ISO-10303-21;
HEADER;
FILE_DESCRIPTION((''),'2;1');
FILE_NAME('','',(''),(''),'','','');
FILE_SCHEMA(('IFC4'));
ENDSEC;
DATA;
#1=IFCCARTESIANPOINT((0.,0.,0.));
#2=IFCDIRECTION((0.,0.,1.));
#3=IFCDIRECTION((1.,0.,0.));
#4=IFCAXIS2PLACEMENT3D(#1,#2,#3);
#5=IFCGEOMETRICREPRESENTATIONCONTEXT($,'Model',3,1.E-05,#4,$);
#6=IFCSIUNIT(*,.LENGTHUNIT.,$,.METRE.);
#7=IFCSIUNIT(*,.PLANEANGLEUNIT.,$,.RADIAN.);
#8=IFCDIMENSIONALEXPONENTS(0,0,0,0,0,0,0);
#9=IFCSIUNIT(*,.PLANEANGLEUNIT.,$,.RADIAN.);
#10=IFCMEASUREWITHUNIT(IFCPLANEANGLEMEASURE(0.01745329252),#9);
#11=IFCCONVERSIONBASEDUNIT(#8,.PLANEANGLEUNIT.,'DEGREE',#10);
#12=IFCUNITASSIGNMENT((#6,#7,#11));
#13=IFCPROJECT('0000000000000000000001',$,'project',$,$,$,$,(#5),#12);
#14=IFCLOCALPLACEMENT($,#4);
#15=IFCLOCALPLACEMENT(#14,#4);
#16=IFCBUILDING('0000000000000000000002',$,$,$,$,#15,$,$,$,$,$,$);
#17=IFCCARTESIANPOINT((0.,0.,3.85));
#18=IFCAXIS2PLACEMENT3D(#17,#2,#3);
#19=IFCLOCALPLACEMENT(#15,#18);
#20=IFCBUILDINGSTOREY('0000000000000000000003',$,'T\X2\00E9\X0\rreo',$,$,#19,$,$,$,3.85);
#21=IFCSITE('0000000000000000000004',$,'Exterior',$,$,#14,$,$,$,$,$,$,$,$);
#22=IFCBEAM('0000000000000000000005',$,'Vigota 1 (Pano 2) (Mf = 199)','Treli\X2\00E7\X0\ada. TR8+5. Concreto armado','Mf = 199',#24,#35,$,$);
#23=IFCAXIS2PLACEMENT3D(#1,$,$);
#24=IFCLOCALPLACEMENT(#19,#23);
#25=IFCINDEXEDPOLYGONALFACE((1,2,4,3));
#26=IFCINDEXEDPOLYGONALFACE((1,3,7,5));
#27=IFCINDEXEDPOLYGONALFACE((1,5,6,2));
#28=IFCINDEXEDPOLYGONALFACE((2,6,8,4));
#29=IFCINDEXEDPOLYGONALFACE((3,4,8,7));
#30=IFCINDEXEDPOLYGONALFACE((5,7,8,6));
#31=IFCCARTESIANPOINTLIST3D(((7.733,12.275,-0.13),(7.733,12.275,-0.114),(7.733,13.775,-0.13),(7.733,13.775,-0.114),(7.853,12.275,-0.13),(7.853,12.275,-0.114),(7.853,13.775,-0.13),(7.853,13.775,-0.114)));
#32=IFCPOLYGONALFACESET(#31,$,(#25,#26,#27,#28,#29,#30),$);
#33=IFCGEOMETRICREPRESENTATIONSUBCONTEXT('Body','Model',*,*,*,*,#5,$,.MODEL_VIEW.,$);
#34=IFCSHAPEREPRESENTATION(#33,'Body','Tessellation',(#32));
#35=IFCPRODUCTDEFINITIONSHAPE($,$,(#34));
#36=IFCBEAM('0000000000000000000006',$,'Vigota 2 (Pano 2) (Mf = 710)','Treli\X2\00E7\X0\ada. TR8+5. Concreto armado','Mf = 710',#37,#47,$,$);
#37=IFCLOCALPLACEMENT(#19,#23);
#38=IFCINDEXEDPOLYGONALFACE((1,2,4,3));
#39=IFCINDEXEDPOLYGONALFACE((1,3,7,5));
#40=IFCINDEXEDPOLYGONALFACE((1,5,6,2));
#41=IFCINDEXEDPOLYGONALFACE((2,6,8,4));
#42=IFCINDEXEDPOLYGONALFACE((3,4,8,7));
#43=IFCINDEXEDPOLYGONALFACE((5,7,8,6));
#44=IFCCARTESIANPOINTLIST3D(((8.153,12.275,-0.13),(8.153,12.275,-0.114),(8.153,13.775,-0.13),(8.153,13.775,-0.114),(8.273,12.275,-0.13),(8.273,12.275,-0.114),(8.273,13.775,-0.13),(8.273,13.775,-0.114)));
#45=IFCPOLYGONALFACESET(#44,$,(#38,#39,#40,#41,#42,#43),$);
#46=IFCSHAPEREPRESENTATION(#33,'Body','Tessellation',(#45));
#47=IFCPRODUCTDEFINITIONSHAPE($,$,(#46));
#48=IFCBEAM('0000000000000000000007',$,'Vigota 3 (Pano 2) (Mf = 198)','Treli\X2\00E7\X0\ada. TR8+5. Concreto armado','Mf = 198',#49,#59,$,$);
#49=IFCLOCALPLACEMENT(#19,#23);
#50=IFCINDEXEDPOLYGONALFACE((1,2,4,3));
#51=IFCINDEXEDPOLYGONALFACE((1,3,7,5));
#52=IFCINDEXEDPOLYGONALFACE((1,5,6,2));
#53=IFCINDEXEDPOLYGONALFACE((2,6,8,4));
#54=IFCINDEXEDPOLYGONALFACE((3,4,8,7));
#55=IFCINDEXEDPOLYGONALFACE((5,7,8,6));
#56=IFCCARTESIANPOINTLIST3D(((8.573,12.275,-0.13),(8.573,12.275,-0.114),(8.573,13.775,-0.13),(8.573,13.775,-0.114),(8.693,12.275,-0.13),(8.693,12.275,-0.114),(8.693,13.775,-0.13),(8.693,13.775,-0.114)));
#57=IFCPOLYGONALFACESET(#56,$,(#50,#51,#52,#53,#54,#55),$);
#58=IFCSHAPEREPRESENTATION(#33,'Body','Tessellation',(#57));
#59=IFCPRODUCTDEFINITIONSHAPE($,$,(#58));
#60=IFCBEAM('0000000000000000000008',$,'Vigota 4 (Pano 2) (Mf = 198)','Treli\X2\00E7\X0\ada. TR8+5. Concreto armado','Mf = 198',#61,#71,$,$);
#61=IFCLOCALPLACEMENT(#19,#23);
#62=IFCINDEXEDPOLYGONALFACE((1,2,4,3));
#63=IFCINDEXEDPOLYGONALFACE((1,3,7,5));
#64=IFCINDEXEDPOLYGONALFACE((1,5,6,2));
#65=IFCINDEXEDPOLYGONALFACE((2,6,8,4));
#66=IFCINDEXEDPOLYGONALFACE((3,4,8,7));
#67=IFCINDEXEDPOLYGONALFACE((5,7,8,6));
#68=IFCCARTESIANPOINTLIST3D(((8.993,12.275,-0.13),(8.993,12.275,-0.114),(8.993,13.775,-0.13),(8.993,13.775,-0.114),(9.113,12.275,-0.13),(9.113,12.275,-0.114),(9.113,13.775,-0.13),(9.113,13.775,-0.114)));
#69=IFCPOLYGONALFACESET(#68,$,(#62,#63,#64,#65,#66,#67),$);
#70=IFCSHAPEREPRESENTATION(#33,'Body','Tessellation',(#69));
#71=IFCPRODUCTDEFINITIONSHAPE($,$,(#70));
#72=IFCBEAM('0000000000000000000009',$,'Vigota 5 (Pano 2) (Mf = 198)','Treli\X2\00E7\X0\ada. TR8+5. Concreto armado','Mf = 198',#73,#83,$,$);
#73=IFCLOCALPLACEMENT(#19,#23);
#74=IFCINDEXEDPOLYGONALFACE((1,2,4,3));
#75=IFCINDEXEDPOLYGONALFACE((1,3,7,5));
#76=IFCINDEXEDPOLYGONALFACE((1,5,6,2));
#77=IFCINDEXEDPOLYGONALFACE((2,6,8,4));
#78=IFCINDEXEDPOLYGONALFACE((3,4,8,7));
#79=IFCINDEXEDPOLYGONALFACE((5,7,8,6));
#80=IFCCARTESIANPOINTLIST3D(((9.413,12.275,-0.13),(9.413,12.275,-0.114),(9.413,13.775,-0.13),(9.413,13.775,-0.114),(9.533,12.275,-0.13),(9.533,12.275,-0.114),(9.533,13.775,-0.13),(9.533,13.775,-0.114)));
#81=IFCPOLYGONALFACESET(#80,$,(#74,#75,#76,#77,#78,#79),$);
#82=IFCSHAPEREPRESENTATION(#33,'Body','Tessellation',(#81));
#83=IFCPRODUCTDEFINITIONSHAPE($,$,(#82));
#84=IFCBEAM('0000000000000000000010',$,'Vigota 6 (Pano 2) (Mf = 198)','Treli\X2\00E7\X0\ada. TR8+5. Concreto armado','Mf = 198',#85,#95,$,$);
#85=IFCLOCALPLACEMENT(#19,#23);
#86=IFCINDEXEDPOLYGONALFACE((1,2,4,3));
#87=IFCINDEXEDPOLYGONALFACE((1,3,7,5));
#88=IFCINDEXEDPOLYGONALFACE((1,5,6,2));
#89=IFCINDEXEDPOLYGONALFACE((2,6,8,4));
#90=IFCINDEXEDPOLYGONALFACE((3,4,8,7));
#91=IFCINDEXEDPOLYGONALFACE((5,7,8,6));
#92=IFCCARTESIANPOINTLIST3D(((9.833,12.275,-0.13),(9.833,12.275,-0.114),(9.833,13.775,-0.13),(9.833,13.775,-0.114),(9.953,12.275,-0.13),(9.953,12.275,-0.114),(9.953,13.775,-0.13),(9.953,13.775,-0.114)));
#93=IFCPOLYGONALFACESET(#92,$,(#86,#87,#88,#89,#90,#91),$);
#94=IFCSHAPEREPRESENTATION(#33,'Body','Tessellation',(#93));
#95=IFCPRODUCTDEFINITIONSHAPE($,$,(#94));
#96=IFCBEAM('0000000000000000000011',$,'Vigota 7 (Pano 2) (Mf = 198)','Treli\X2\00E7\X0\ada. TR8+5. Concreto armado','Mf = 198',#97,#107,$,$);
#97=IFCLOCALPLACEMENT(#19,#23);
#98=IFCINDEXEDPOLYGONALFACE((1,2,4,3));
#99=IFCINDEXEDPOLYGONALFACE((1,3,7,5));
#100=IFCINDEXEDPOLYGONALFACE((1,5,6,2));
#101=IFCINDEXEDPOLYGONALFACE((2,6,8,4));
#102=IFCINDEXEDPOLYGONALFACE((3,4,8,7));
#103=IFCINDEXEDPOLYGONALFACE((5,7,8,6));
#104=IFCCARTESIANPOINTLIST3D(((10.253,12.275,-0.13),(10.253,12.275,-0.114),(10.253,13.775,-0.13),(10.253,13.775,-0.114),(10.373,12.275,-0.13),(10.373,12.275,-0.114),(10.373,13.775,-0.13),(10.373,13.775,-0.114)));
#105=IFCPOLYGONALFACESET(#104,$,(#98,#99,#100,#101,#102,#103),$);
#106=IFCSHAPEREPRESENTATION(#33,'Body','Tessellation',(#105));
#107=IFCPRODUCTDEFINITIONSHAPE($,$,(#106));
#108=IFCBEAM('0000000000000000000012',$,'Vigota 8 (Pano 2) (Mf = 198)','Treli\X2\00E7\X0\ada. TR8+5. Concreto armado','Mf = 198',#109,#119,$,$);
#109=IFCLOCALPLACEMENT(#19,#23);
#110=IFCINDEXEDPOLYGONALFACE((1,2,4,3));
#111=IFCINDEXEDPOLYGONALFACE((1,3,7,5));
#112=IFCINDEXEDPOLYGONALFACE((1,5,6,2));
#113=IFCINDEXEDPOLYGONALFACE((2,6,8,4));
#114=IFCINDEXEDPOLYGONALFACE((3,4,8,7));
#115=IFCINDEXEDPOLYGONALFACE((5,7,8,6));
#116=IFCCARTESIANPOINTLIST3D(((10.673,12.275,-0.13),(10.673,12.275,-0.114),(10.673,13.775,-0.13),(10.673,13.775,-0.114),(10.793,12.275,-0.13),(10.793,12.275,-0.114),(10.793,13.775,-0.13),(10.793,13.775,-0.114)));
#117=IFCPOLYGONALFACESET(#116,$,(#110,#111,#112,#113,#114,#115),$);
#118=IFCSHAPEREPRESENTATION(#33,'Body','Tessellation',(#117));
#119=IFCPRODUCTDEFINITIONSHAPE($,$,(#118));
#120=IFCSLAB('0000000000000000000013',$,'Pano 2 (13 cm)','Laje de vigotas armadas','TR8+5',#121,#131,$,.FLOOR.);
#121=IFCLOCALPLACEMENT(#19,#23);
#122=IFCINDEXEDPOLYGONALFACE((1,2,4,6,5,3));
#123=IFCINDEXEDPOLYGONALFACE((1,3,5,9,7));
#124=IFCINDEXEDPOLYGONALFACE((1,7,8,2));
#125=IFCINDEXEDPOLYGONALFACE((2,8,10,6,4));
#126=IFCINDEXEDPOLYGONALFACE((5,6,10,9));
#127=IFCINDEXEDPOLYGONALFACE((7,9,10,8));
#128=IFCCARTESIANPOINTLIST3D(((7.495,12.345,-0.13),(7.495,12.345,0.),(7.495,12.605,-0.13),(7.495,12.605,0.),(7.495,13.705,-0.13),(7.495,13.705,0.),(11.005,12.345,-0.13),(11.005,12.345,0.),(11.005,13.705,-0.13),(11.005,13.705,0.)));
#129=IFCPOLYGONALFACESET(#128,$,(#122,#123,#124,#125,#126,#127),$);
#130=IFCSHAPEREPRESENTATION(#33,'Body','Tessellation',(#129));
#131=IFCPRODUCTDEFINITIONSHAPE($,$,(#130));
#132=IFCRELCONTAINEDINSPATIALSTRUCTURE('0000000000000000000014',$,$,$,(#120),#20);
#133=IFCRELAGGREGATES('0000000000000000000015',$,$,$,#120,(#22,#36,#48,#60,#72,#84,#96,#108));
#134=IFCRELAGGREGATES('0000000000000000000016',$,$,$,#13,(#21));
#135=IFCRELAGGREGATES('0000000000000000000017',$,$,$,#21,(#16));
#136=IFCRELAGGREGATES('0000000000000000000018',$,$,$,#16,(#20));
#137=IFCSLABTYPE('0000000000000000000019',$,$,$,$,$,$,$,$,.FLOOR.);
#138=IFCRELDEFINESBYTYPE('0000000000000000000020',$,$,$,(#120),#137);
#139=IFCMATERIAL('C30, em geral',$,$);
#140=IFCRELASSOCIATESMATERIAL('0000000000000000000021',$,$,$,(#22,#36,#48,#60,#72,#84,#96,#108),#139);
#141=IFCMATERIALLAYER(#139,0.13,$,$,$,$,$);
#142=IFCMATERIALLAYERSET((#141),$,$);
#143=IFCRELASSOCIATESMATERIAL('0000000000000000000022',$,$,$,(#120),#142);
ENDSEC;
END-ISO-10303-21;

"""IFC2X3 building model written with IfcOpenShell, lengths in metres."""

from ifc_helpers import new_model, entity, si_unit, converted_unit, frame, origin_with_axes, place, context, subcontext, project, spatial, polyline, outline, extrude, material, layer, layer_set, layer_usage, type_object, element, aggregate, save


model = new_model("IFC2X3")

# Units and contexts
model_context = context("Model", 3, precision=1e-05, world=origin_with_axes())
body_context = subcontext(model_context, "Body", "Model", "MODEL_VIEW")
ifc_project = project(units=[si_unit("LENGTHUNIT", "METRE"), si_unit("PLANEANGLEUNIT", "RADIAN"), converted_unit("PLANEANGLEUNIT", "DEGREE", entity("IfcPlaneAngleMeasure", 0.01745329252), si_unit("PLANEANGLEUNIT", "RADIAN"), dimensions=[0, 0, 0, 0, 0, 0, 0])], contexts=[model_context])

# Beams
ifc_material = material(Name="C30, em geral")
site_placement = place(None, origin_with_axes())
building_placement = place(site_placement, origin_with_axes())
storey_placement = place(building_placement, frame((0.0, 0.0, 3.85), z_axis=(0.0, 0.0, 1.0), x_axis=(1.0, 0.0, 0.0)))
beam_1_placement = place(storey_placement, frame((7.793, 12.275, -0.122), z_axis=(0.0, 1.0, 0.0), x_axis=(-1.0, 0.0, 0.0)))
beam_1 = element("IfcBeam", 1, at=beam_1_placement, material=ifc_material, Name="Vigota 1 (Pano 2) (Mf = 199)", Description="Treliçada. TR8+5. Concreto armado", ObjectType="Mf = 199", context=body_context, shape_type="SweptSolid", body=[
    extrude(outline(polyline([(0.06, 0.008), (-0.06, 0.008), (-0.06, -0.008), (0.06, -0.008), (0.06, 0.008)])), origin_with_axes(), (0.0, 0.0, 1.0), 1.5),
])
beam_2_placement = place(storey_placement, frame((8.213, 12.275, -0.122), z_axis=(0.0, 1.0, 0.0), x_axis=(-1.0, 0.0, 0.0)))
beam_2 = element("IfcBeam", 2, at=beam_2_placement, material=ifc_material, Name="Vigota 2 (Pano 2) (Mf = 710)", Description="Treliçada. TR8+5. Concreto armado", ObjectType="Mf = 710", context=body_context, shape_type="SweptSolid", body=[
    extrude(outline(polyline([(0.06, 0.008), (-0.06, 0.008), (-0.06, -0.008), (0.06, -0.008), (0.06, 0.008)])), origin_with_axes(), (0.0, 0.0, 1.0), 1.5),
])
beam_3_placement = place(storey_placement, frame((8.633, 12.275, -0.122), z_axis=(0.0, 1.0, 0.0), x_axis=(-1.0, 0.0, 0.0)))
beam_3 = element("IfcBeam", 3, at=beam_3_placement, material=ifc_material, Name="Vigota 3 (Pano 2) (Mf = 198)", Description="Treliçada. TR8+5. Concreto armado", ObjectType="Mf = 198", context=body_context, shape_type="SweptSolid", body=[
    extrude(outline(polyline([(0.06, 0.008), (-0.06, 0.008), (-0.06, -0.008), (0.06, -0.008), (0.06, 0.008)])), origin_with_axes(), (0.0, 0.0, 1.0), 1.5),
])
beam_4_placement = place(storey_placement, frame((9.053, 12.275, -0.122), z_axis=(0.0, 1.0, 0.0), x_axis=(-1.0, 0.0, 0.0)))
beam_4 = element("IfcBeam", 4, at=beam_4_placement, material=ifc_material, Name="Vigota 4 (Pano 2) (Mf = 198)", Description="Treliçada. TR8+5. Concreto armado", ObjectType="Mf = 198", context=body_context, shape_type="SweptSolid", body=[
    extrude(outline(polyline([(0.06, 0.008), (-0.06, 0.008), (-0.06, -0.008), (0.06, -0.008), (0.06, 0.008)])), origin_with_axes(), (0.0, 0.0, 1.0), 1.5),
])
beam_5_placement = place(storey_placement, frame((9.473, 12.275, -0.122), z_axis=(0.0, 1.0, 0.0), x_axis=(-1.0, 0.0, 0.0)))
beam_5 = element("IfcBeam", 5, at=beam_5_placement, material=ifc_material, Name="Vigota 5 (Pano 2) (Mf = 198)", Description="Treliçada. TR8+5. Concreto armado", ObjectType="Mf = 198", context=body_context, shape_type="SweptSolid", body=[
    extrude(outline(polyline([(0.06, 0.008), (-0.06, 0.008), (-0.06, -0.008), (0.06, -0.008), (0.06, 0.008)])), origin_with_axes(), (0.0, 0.0, 1.0), 1.5),
])
beam_6_placement = place(storey_placement, frame((9.893, 12.275, -0.122), z_axis=(0.0, 1.0, 0.0), x_axis=(-1.0, 0.0, 0.0)))
beam_6 = element("IfcBeam", 6, at=beam_6_placement, material=ifc_material, Name="Vigota 6 (Pano 2) (Mf = 198)", Description="Treliçada. TR8+5. Concreto armado", ObjectType="Mf = 198", context=body_context, shape_type="SweptSolid", body=[
    extrude(outline(polyline([(0.06, 0.008), (-0.06, 0.008), (-0.06, -0.008), (0.06, -0.008), (0.06, 0.008)])), origin_with_axes(), (0.0, 0.0, 1.0), 1.5),
])
beam_7_placement = place(storey_placement, frame((10.313, 12.275, -0.122), z_axis=(0.0, 1.0, 0.0), x_axis=(-1.0, 0.0, 0.0)))
beam_7 = element("IfcBeam", 7, at=beam_7_placement, material=ifc_material, Name="Vigota 7 (Pano 2) (Mf = 198)", Description="Treliçada. TR8+5. Concreto armado", ObjectType="Mf = 198", context=body_context, shape_type="SweptSolid", body=[
    extrude(outline(polyline([(0.06, 0.008), (-0.06, 0.008), (-0.06, -0.008), (0.06, -0.008), (0.06, 0.008)])), origin_with_axes(), (0.0, 0.0, 1.0), 1.5),
])
beam_8_placement = place(storey_placement, frame((10.733, 12.275, -0.122), z_axis=(0.0, 1.0, 0.0), x_axis=(-1.0, 0.0, 0.0)))
beam_8 = element("IfcBeam", 8, at=beam_8_placement, material=ifc_material, Name="Vigota 8 (Pano 2) (Mf = 198)", Description="Treliçada. TR8+5. Concreto armado", ObjectType="Mf = 198", context=body_context, shape_type="SweptSolid", body=[
    extrude(outline(polyline([(0.06, 0.008), (-0.06, 0.008), (-0.06, -0.008), (0.06, -0.008), (0.06, 0.008)])), origin_with_axes(), (0.0, 0.0, 1.0), 1.5),
])

# Site, building, storey
site = spatial("IfcSite", under=ifc_project, at=site_placement, Name="Exterior")
building = spatial("IfcBuilding", under=site, at=building_placement)
storey = spatial("IfcBuildingStorey", under=building, at=storey_placement, Name="Térreo", Elevation=3.85)

# Slab
ifc_layer_1 = layer(ifc_material, 0.13)
ifc_layer_set_1 = layer_set([ifc_layer_1])
ifc_layer_usage_1 = layer_usage(ifc_layer_set_1, "AXIS3", "POSITIVE", 0.0)
slab_type = type_object("IfcSlabType", PredefinedType="FLOOR")
slab_1_placement = place(storey_placement, frame((0.0, 0.0, -0.13), z_axis=(0.0, 0.0, 1.0), x_axis=(1.0, 0.0, 0.0)))
slab_1 = element("IfcSlab", 9, at=slab_1_placement, inside=storey, type_object=slab_type, material=ifc_layer_usage_1, Name="Pano 2 (13 cm)", Description="Laje de vigotas armadas", ObjectType="TR8+5", PredefinedType="FLOOR", context=body_context, shape_type="SweptSolid", body=[
    extrude(outline(polyline([(11.005, 13.705), (7.495, 13.705), (7.495, 12.605), (7.495, 12.345), (11.005, 12.345), (11.005, 13.705)])), origin_with_axes(), (0.0, 0.0, 1.0), 0.13),
])
aggregate(slab_1, [beam_1, beam_2, beam_3, beam_4, beam_5, beam_6, beam_7, beam_8])

save(model, "model.ifc")
